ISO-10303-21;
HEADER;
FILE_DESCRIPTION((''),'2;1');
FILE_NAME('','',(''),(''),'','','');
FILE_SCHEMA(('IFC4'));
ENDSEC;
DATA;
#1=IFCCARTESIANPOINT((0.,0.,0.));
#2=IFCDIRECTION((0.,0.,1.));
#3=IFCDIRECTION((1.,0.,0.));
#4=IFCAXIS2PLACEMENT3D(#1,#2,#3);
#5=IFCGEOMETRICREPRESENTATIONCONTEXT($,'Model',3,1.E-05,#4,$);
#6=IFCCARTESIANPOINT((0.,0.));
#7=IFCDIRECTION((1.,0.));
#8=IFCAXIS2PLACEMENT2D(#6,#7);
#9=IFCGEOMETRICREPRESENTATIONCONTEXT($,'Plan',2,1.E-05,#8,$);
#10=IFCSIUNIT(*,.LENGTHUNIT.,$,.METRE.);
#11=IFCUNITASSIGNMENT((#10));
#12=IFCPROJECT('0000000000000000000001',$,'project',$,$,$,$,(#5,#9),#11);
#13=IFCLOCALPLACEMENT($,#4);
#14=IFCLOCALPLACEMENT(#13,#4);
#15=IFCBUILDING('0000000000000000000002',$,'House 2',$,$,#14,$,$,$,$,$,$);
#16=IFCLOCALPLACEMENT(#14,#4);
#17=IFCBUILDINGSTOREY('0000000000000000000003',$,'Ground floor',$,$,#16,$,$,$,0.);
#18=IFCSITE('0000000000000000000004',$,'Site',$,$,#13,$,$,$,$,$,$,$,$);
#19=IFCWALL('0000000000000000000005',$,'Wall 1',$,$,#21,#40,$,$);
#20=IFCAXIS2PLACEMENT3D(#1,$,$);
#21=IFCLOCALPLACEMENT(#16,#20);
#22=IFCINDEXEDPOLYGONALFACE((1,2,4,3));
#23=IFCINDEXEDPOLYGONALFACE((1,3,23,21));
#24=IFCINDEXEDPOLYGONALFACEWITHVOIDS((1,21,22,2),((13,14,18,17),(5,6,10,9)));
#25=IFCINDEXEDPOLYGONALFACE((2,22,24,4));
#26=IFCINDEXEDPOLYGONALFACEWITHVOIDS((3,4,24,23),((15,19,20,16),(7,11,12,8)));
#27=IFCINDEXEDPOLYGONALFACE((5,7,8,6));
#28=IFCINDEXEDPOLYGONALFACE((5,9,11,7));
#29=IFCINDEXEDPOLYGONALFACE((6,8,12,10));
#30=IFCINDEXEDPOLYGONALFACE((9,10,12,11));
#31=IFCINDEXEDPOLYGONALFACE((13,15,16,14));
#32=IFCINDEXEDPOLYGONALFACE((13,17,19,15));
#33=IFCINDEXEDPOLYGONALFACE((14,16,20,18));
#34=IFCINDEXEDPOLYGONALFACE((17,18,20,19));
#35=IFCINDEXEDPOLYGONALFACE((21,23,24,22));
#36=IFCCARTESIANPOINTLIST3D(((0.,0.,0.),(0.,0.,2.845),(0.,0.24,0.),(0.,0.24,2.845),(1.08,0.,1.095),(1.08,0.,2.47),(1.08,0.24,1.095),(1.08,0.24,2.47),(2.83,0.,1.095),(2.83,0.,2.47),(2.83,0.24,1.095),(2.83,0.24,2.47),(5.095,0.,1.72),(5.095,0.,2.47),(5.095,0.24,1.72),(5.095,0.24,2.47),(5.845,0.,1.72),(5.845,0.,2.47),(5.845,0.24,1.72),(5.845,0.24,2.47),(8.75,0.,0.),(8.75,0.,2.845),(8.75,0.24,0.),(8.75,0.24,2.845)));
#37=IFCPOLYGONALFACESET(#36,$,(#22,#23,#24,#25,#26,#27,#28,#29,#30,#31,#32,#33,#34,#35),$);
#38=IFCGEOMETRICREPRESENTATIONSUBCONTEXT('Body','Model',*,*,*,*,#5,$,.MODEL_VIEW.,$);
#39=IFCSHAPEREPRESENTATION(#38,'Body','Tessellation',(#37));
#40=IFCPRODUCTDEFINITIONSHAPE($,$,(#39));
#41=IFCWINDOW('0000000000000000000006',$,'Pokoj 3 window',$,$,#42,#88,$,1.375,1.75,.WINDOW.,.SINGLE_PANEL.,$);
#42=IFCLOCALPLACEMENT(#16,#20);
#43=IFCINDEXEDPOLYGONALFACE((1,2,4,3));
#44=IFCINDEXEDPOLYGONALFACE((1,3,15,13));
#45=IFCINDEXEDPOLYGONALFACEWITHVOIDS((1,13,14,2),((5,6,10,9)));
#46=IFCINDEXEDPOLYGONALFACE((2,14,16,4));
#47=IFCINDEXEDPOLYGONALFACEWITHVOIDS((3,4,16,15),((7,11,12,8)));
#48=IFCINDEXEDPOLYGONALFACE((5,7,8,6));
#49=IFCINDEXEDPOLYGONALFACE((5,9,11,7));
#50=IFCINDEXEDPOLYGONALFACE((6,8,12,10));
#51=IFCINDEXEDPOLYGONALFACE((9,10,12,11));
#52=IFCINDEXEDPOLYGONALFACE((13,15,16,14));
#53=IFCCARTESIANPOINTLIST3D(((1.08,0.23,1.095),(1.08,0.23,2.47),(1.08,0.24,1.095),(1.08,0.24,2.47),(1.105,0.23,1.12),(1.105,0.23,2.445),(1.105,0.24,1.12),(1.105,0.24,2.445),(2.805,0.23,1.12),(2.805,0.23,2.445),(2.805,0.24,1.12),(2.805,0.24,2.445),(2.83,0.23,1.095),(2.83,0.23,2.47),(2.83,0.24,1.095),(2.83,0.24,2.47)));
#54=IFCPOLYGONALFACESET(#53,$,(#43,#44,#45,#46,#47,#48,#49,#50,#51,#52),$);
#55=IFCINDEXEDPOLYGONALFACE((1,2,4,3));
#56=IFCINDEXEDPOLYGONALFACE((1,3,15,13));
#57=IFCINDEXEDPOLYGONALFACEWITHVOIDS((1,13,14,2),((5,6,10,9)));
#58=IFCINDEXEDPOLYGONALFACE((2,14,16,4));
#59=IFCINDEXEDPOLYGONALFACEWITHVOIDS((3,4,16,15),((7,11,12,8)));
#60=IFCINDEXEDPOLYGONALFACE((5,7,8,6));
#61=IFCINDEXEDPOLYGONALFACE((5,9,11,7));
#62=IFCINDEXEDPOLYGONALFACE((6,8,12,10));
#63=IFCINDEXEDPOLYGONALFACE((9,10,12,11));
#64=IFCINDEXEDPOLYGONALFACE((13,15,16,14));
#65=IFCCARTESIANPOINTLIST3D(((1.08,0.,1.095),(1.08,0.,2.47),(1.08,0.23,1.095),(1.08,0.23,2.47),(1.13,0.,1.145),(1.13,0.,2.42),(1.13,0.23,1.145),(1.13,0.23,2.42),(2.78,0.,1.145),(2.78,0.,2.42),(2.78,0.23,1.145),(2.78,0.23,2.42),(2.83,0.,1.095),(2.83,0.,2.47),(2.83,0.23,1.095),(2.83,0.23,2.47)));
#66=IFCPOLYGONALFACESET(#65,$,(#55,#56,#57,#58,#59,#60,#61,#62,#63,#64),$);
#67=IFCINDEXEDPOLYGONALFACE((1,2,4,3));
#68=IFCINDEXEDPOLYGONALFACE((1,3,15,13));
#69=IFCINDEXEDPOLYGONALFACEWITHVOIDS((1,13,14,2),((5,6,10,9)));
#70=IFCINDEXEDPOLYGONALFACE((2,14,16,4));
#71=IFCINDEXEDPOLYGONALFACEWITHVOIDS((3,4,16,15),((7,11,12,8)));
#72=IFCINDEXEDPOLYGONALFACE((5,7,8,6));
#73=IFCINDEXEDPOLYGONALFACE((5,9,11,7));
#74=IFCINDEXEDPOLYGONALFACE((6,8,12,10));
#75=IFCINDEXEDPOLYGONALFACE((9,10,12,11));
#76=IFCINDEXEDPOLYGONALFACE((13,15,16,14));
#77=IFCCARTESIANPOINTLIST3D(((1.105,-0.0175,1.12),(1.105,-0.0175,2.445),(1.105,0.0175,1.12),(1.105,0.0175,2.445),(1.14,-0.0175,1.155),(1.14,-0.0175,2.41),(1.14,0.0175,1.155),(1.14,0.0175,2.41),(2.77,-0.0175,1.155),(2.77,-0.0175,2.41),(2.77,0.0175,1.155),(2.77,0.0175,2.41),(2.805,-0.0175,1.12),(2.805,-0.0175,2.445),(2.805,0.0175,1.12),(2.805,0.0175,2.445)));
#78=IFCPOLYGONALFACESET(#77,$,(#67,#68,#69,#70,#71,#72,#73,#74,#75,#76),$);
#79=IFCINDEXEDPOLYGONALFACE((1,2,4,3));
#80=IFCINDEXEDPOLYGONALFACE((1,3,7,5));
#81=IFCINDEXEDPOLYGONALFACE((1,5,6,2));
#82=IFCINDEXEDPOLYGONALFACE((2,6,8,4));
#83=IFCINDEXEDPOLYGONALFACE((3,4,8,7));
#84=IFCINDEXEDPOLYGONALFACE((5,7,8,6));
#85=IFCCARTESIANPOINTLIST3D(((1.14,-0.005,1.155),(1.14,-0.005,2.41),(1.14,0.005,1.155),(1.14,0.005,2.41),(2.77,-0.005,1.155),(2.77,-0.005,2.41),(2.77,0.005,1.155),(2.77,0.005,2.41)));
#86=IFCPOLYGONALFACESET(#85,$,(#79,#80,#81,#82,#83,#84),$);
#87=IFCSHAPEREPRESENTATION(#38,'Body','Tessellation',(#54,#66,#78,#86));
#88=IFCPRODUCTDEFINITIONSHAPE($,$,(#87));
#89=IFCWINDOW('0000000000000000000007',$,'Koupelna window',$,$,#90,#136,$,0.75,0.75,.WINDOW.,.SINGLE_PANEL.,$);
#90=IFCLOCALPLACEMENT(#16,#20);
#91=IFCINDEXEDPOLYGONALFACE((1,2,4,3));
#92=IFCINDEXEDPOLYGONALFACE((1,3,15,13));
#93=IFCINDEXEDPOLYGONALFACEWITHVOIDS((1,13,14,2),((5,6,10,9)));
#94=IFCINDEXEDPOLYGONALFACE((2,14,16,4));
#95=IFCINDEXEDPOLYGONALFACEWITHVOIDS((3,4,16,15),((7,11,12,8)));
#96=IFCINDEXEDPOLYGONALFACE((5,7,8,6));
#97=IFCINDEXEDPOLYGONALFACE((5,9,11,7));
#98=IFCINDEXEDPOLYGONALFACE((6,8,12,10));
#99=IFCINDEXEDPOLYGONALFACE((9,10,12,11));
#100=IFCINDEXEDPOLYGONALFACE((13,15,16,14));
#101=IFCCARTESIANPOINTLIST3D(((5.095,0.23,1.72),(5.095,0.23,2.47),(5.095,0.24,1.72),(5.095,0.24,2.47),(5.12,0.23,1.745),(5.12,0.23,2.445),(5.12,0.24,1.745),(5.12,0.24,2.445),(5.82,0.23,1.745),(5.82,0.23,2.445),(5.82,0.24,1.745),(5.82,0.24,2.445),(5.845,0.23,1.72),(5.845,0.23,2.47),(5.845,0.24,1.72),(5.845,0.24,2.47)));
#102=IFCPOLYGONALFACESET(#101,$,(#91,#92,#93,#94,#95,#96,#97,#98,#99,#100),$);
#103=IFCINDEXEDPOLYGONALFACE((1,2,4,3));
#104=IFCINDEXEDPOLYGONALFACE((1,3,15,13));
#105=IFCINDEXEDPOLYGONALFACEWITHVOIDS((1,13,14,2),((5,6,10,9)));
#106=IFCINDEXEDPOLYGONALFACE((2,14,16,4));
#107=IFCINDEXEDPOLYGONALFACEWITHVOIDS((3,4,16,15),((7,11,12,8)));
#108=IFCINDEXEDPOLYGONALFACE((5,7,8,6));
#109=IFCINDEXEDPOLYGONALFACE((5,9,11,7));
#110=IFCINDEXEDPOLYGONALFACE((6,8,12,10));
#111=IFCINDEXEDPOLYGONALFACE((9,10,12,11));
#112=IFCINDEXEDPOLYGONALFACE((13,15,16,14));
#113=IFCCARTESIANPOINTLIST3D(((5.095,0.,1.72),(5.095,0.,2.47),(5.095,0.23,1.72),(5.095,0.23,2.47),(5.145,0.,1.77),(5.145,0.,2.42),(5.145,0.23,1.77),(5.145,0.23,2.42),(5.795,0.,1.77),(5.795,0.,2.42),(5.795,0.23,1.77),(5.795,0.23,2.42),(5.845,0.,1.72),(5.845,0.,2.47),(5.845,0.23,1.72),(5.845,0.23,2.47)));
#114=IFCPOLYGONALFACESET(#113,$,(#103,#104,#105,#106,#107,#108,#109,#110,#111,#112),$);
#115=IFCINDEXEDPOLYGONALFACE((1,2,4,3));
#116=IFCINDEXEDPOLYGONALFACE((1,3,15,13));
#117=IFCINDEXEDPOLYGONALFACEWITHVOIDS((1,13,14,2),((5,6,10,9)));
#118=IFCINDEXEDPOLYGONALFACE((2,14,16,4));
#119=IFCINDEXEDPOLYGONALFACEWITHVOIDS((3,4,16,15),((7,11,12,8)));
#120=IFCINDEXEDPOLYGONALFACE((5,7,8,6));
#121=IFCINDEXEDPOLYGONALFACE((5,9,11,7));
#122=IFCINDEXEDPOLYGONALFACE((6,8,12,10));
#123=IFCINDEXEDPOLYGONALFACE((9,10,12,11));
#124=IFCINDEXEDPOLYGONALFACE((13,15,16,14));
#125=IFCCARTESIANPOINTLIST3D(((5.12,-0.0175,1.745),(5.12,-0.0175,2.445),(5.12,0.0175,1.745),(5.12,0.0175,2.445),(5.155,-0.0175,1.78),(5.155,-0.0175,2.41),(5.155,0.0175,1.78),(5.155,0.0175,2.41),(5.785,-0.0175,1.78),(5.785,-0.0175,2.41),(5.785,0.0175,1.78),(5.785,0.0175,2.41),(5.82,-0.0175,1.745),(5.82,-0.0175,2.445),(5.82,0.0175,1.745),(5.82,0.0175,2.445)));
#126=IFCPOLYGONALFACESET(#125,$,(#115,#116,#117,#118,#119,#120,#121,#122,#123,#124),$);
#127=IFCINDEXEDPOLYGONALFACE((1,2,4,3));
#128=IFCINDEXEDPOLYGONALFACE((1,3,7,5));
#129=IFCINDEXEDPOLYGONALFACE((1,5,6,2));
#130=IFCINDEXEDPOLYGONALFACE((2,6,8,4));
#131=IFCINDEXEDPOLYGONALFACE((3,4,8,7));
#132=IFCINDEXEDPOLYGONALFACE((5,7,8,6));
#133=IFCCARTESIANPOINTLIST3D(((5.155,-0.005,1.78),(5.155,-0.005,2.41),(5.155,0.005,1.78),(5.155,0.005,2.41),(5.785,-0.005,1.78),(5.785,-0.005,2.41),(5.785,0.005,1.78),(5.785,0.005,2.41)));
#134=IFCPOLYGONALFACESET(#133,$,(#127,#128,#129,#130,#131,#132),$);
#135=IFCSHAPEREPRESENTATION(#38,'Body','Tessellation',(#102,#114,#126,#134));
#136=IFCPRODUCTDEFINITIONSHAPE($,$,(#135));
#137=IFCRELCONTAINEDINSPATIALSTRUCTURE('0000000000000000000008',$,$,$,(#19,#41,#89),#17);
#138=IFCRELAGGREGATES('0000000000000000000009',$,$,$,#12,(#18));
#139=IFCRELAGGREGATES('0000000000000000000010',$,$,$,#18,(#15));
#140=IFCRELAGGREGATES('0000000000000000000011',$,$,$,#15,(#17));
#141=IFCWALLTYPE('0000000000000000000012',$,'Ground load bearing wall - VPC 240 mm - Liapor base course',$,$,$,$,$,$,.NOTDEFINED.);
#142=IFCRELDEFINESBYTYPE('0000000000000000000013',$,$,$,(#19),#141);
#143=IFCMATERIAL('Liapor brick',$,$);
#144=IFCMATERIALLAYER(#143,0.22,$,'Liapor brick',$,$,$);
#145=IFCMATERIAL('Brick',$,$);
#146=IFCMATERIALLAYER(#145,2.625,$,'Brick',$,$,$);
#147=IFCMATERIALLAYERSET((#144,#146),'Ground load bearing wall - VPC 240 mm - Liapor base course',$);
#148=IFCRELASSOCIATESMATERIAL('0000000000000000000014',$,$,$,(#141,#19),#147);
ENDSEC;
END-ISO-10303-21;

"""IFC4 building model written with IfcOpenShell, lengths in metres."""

from ifc_helpers import new_model, entity, si_unit, frame, origin_with_axes, origin_2d_with_axis, place, context, subcontext, project, spatial, line, indexed_curve, outline, extrude, shape, material, layer, layer_set, layer_usage, type_object, element, fill, save


model = new_model("IFC4")

# Units and contexts
model_context = context("Model", 3, precision=1e-05, world=origin_with_axes())
plan_context = context("Plan", 2, precision=1e-05, world=origin_2d_with_axis())
body_context_1 = subcontext(model_context, "Body", "Model", "MODEL_VIEW")
body_context_2 = subcontext(plan_context, "Body", "Plan", "PLAN_VIEW")
ifc_project = project(units=[si_unit("LENGTHUNIT", "METRE")], contexts=[model_context, plan_context])

# Site, building, storey
site_placement = place(None, origin_with_axes())
site = spatial("IfcSite", under=ifc_project, at=site_placement, Name="Site")
building_placement = place(site_placement, origin_with_axes())
building = spatial("IfcBuilding", under=site, at=building_placement, Name="House 2")
storey_placement = place(building_placement, origin_with_axes())
storey = spatial("IfcBuildingStorey", under=building, at=storey_placement, Name="Ground floor", Elevation=0.0)

# Wall, openings, windows
ifc_material_1 = material(Name="Liapor brick")
ifc_layer_1 = layer(ifc_material_1, 0.22, Name="Liapor brick")
ifc_material_2 = material(Name="Brick")
ifc_layer_2 = layer(ifc_material_2, 2.625, Name="Brick")
ifc_layer_set_1 = layer_set([ifc_layer_1, ifc_layer_2], Name="Ground load bearing wall - VPC 240 mm - Liapor base course")
ifc_layer_usage_1 = layer_usage(ifc_layer_set_1, "AXIS3", "POSITIVE", 0.0)
wall_type_1 = type_object("IfcWallType", Name="Ground load bearing wall - VPC 240 mm - Liapor base course", PredefinedType="NOTDEFINED", material=ifc_layer_set_1)
wall_1_placement = place(storey_placement, origin_with_axes())
wall_1 = element("IfcWall", 1, at=wall_1_placement, inside=storey, type_object=wall_type_1, material=ifc_layer_usage_1, Name="Wall 1", context=body_context_1, shape_type="SweptSolid", body=[
    extrude(outline(indexed_curve([(0.0, 0.0), (0.0, 0.24), (8.75, 0.24), (8.75, 0.0), (0.0, 0.0)], self_intersect=False)), origin_with_axes(), (0.0, 0.0, 1.0), 2.845),
])
opening_1_placement = place(wall_1_placement, frame((1.08, 0.0, 1.095), z_axis=(0.0, 0.0, 1.0), x_axis=(1.0, 0.0, 0.0)))
opening_1 = element("IfcOpeningElement", 2, at=opening_1_placement, cuts=wall_1, PredefinedType="OPENING", context=body_context_1, shape_type="SweptSolid", body=[
    extrude(outline(indexed_curve([(0.0, 0.0), (0.0, 0.34), (1.75, 0.34), (1.75, 0.0), (0.0, 0.0)], self_intersect=False)), frame((0.0, -0.05, 0.0), z_axis=(0.0, 0.0, 1.0), x_axis=(1.0, 0.0, 0.0)), (0.0, 0.0, 1.0), 1.375),
])
opening_2_placement = place(wall_1_placement, frame((5.095, 0.0, 1.72), z_axis=(0.0, 0.0, 1.0), x_axis=(1.0, 0.0, 0.0)))
opening_2 = element("IfcOpeningElement", 3, at=opening_2_placement, cuts=wall_1, PredefinedType="OPENING", context=body_context_1, shape_type="SweptSolid", body=[
    extrude(outline(indexed_curve([(0.0, 0.0), (0.0, 0.34), (0.75, 0.34), (0.75, 0.0), (0.0, 0.0)], self_intersect=False)), frame((0.0, -0.05, 0.0), z_axis=(0.0, 0.0, 1.0), x_axis=(1.0, 0.0, 0.0)), (0.0, 0.0, 1.0), 0.75),
])
window_1_placement = place(opening_1_placement, origin_with_axes())
window_1 = element("IfcWindow", 4, at=window_1_placement, inside=storey, Name="Pokoj 3 window", OverallHeight=1.375, OverallWidth=1.75, PartitioningType="SINGLE_PANEL", PredefinedType="WINDOW", shapes=[
    shape(body_context_1, "Body", "SweptSolid", [extrude(outline(indexed_curve([(0.0, 0.0), (1.75, 0.0), (1.75, 1.375), (0.0, 1.375)], segments=[line(1, 2, 3, 4, 1)]), holes=[indexed_curve([(0.025, 0.025), (1.725, 0.025), (1.725, 1.35), (0.025, 1.35)], segments=[line(1, 2, 3, 4, 1)])]), frame((0.0, 0.23, 0.0), z_axis=(0.0, -1.0, 0.0), x_axis=(1.0, 0.0, 0.0)), (0.0, 0.0, -1.0), 0.01), extrude(outline(indexed_curve([(0.0, 0.0), (1.75, 0.0), (1.75, 1.375), (0.0, 1.375)], segments=[line(1, 2, 3, 4, 1)]), holes=[indexed_curve([(0.05, 0.05), (1.7, 0.05), (1.7, 1.325), (0.05, 1.325)], segments=[line(1, 2, 3, 4, 1)])]), frame((0.0, 0.0, 0.0), z_axis=(0.0, -1.0, 0.0), x_axis=(1.0, 0.0, 0.0)), (0.0, 0.0, -1.0), 0.23), extrude(outline(indexed_curve([(0.0, 0.0), (1.7, 0.0), (1.7, 1.325), (0.0, 1.325)], segments=[line(1, 2, 3, 4, 1)]), holes=[indexed_curve([(0.035, 0.035), (1.665, 0.035), (1.665, 1.29), (0.035, 1.29)], segments=[line(1, 2, 3, 4, 1)])]), frame((0.025, -0.0175, 0.025), z_axis=(0.0, -1.0, 0.0), x_axis=(1.0, 0.0, 0.0)), (0.0, 0.0, -1.0), 0.035), extrude(outline(indexed_curve([(0.035, 0.035), (1.665, 0.035), (1.665, 1.29), (0.035, 1.29)], segments=[line(1, 2, 3, 4, 1)])), frame((0.025, -0.005, 0.025), z_axis=(0.0, -1.0, 0.0), x_axis=(1.0, 0.0, 0.0)), (0.0, 0.0, -1.0), 0.01)]),
    shape(body_context_2, "Body", "Curve2D", [entity("IfcIndexedPolyCurve", entity("IfcCartesianPointList2D", [[0.05, 0.0], [1.7, 0.0]])), entity("IfcIndexedPolyCurve", entity("IfcCartesianPointList2D", [[0.0, 0.24], [0.025, 0.24], [0.025, 0.23], [0.05, 0.23], [0.05, 0.0], [0.0, 0.0]]), [entity("IfcLineIndex", [1, 2, 3, 4, 5, 6, 1])]), entity("IfcIndexedPolyCurve", entity("IfcCartesianPointList2D", [[1.75, 0.24], [1.725, 0.24], [1.725, 0.23], [1.7, 0.23], [1.7, 0.0], [1.75, 0.0]]), [entity("IfcLineIndex", [1, 2, 3, 4, 5, 6, 1])]), entity("IfcIndexedPolyCurve", entity("IfcCartesianPointList2D", [[0.025, -0.0175], [0.06, -0.0175], [0.06, 0.0175], [0.025, 0.0175]]), [entity("IfcLineIndex", [1, 2, 3, 4, 1])]), entity("IfcIndexedPolyCurve", entity("IfcCartesianPointList2D", [[1.725, -0.0175], [1.69, -0.0175], [1.69, 0.0175], [1.725, 0.0175]]), [entity("IfcLineIndex", [1, 2, 3, 4, 1])]), entity("IfcIndexedPolyCurve", entity("IfcCartesianPointList2D", [[0.06, -0.0175], [1.69, -0.0175]])), entity("IfcIndexedPolyCurve", entity("IfcCartesianPointList2D", [[0.06, 0.0175], [1.69, 0.0175]])), entity("IfcIndexedPolyCurve", entity("IfcCartesianPointList2D", [[0.06, 0.0], [1.69, 0.0]]))]),
])
fill(opening_1, window_1)
window_2_placement = place(opening_2_placement, origin_with_axes())
window_2 = element("IfcWindow", 5, at=window_2_placement, inside=storey, Name="Koupelna window", OverallHeight=0.75, OverallWidth=0.75, PartitioningType="SINGLE_PANEL", PredefinedType="WINDOW", shapes=[
    shape(body_context_1, "Body", "SweptSolid", [extrude(outline(indexed_curve([(0.0, 0.0), (0.75, 0.0), (0.75, 0.75), (0.0, 0.75)], segments=[line(1, 2, 3, 4, 1)]), holes=[indexed_curve([(0.025, 0.025), (0.725, 0.025), (0.725, 0.725), (0.025, 0.725)], segments=[line(1, 2, 3, 4, 1)])]), frame((0.0, 0.23, 0.0), z_axis=(0.0, -1.0, 0.0), x_axis=(1.0, 0.0, 0.0)), (0.0, 0.0, -1.0), 0.01), extrude(outline(indexed_curve([(0.0, 0.0), (0.75, 0.0), (0.75, 0.75), (0.0, 0.75)], segments=[line(1, 2, 3, 4, 1)]), holes=[indexed_curve([(0.05, 0.05), (0.7, 0.05), (0.7, 0.7), (0.05, 0.7)], segments=[line(1, 2, 3, 4, 1)])]), frame((0.0, 0.0, 0.0), z_axis=(0.0, -1.0, 0.0), x_axis=(1.0, 0.0, 0.0)), (0.0, 0.0, -1.0), 0.23), extrude(outline(indexed_curve([(0.0, 0.0), (0.7, 0.0), (0.7, 0.7), (0.0, 0.7)], segments=[line(1, 2, 3, 4, 1)]), holes=[indexed_curve([(0.035, 0.035), (0.665, 0.035), (0.665, 0.665), (0.035, 0.665)], segments=[line(1, 2, 3, 4, 1)])]), frame((0.025, -0.0175, 0.025), z_axis=(0.0, -1.0, 0.0), x_axis=(1.0, 0.0, 0.0)), (0.0, 0.0, -1.0), 0.035), extrude(outline(indexed_curve([(0.035, 0.035), (0.665, 0.035), (0.665, 0.665), (0.035, 0.665)], segments=[line(1, 2, 3, 4, 1)])), frame((0.025, -0.005, 0.025), z_axis=(0.0, -1.0, 0.0), x_axis=(1.0, 0.0, 0.0)), (0.0, 0.0, -1.0), 0.01)]),
    shape(body_context_2, "Body", "Curve2D", [entity("IfcIndexedPolyCurve", entity("IfcCartesianPointList2D", [[0.05, 0.0], [0.7, 0.0]])), entity("IfcIndexedPolyCurve", entity("IfcCartesianPointList2D", [[0.0, 0.24], [0.025, 0.24], [0.025, 0.23], [0.05, 0.23], [0.05, 0.0], [0.0, 0.0]]), [entity("IfcLineIndex", [1, 2, 3, 4, 5, 6, 1])]), entity("IfcIndexedPolyCurve", entity("IfcCartesianPointList2D", [[0.75, 0.24], [0.725, 0.24], [0.725, 0.23], [0.7, 0.23], [0.7, 0.0], [0.75, 0.0]]), [entity("IfcLineIndex", [1, 2, 3, 4, 5, 6, 1])]), entity("IfcIndexedPolyCurve", entity("IfcCartesianPointList2D", [[0.025, -0.0175], [0.06, -0.0175], [0.06, 0.0175], [0.025, 0.0175]]), [entity("IfcLineIndex", [1, 2, 3, 4, 1])]), entity("IfcIndexedPolyCurve", entity("IfcCartesianPointList2D", [[0.725, -0.0175], [0.69, -0.0175], [0.69, 0.0175], [0.725, 0.0175]]), [entity("IfcLineIndex", [1, 2, 3, 4, 1])]), entity("IfcIndexedPolyCurve", entity("IfcCartesianPointList2D", [[0.06, -0.0175], [0.69, -0.0175]])), entity("IfcIndexedPolyCurve", entity("IfcCartesianPointList2D", [[0.06, 0.0175], [0.69, 0.0175]])), entity("IfcIndexedPolyCurve", entity("IfcCartesianPointList2D", [[0.06, 0.0], [0.69, 0.0]]))]),
])
fill(opening_2, window_2)

save(model, "model.ifc")
